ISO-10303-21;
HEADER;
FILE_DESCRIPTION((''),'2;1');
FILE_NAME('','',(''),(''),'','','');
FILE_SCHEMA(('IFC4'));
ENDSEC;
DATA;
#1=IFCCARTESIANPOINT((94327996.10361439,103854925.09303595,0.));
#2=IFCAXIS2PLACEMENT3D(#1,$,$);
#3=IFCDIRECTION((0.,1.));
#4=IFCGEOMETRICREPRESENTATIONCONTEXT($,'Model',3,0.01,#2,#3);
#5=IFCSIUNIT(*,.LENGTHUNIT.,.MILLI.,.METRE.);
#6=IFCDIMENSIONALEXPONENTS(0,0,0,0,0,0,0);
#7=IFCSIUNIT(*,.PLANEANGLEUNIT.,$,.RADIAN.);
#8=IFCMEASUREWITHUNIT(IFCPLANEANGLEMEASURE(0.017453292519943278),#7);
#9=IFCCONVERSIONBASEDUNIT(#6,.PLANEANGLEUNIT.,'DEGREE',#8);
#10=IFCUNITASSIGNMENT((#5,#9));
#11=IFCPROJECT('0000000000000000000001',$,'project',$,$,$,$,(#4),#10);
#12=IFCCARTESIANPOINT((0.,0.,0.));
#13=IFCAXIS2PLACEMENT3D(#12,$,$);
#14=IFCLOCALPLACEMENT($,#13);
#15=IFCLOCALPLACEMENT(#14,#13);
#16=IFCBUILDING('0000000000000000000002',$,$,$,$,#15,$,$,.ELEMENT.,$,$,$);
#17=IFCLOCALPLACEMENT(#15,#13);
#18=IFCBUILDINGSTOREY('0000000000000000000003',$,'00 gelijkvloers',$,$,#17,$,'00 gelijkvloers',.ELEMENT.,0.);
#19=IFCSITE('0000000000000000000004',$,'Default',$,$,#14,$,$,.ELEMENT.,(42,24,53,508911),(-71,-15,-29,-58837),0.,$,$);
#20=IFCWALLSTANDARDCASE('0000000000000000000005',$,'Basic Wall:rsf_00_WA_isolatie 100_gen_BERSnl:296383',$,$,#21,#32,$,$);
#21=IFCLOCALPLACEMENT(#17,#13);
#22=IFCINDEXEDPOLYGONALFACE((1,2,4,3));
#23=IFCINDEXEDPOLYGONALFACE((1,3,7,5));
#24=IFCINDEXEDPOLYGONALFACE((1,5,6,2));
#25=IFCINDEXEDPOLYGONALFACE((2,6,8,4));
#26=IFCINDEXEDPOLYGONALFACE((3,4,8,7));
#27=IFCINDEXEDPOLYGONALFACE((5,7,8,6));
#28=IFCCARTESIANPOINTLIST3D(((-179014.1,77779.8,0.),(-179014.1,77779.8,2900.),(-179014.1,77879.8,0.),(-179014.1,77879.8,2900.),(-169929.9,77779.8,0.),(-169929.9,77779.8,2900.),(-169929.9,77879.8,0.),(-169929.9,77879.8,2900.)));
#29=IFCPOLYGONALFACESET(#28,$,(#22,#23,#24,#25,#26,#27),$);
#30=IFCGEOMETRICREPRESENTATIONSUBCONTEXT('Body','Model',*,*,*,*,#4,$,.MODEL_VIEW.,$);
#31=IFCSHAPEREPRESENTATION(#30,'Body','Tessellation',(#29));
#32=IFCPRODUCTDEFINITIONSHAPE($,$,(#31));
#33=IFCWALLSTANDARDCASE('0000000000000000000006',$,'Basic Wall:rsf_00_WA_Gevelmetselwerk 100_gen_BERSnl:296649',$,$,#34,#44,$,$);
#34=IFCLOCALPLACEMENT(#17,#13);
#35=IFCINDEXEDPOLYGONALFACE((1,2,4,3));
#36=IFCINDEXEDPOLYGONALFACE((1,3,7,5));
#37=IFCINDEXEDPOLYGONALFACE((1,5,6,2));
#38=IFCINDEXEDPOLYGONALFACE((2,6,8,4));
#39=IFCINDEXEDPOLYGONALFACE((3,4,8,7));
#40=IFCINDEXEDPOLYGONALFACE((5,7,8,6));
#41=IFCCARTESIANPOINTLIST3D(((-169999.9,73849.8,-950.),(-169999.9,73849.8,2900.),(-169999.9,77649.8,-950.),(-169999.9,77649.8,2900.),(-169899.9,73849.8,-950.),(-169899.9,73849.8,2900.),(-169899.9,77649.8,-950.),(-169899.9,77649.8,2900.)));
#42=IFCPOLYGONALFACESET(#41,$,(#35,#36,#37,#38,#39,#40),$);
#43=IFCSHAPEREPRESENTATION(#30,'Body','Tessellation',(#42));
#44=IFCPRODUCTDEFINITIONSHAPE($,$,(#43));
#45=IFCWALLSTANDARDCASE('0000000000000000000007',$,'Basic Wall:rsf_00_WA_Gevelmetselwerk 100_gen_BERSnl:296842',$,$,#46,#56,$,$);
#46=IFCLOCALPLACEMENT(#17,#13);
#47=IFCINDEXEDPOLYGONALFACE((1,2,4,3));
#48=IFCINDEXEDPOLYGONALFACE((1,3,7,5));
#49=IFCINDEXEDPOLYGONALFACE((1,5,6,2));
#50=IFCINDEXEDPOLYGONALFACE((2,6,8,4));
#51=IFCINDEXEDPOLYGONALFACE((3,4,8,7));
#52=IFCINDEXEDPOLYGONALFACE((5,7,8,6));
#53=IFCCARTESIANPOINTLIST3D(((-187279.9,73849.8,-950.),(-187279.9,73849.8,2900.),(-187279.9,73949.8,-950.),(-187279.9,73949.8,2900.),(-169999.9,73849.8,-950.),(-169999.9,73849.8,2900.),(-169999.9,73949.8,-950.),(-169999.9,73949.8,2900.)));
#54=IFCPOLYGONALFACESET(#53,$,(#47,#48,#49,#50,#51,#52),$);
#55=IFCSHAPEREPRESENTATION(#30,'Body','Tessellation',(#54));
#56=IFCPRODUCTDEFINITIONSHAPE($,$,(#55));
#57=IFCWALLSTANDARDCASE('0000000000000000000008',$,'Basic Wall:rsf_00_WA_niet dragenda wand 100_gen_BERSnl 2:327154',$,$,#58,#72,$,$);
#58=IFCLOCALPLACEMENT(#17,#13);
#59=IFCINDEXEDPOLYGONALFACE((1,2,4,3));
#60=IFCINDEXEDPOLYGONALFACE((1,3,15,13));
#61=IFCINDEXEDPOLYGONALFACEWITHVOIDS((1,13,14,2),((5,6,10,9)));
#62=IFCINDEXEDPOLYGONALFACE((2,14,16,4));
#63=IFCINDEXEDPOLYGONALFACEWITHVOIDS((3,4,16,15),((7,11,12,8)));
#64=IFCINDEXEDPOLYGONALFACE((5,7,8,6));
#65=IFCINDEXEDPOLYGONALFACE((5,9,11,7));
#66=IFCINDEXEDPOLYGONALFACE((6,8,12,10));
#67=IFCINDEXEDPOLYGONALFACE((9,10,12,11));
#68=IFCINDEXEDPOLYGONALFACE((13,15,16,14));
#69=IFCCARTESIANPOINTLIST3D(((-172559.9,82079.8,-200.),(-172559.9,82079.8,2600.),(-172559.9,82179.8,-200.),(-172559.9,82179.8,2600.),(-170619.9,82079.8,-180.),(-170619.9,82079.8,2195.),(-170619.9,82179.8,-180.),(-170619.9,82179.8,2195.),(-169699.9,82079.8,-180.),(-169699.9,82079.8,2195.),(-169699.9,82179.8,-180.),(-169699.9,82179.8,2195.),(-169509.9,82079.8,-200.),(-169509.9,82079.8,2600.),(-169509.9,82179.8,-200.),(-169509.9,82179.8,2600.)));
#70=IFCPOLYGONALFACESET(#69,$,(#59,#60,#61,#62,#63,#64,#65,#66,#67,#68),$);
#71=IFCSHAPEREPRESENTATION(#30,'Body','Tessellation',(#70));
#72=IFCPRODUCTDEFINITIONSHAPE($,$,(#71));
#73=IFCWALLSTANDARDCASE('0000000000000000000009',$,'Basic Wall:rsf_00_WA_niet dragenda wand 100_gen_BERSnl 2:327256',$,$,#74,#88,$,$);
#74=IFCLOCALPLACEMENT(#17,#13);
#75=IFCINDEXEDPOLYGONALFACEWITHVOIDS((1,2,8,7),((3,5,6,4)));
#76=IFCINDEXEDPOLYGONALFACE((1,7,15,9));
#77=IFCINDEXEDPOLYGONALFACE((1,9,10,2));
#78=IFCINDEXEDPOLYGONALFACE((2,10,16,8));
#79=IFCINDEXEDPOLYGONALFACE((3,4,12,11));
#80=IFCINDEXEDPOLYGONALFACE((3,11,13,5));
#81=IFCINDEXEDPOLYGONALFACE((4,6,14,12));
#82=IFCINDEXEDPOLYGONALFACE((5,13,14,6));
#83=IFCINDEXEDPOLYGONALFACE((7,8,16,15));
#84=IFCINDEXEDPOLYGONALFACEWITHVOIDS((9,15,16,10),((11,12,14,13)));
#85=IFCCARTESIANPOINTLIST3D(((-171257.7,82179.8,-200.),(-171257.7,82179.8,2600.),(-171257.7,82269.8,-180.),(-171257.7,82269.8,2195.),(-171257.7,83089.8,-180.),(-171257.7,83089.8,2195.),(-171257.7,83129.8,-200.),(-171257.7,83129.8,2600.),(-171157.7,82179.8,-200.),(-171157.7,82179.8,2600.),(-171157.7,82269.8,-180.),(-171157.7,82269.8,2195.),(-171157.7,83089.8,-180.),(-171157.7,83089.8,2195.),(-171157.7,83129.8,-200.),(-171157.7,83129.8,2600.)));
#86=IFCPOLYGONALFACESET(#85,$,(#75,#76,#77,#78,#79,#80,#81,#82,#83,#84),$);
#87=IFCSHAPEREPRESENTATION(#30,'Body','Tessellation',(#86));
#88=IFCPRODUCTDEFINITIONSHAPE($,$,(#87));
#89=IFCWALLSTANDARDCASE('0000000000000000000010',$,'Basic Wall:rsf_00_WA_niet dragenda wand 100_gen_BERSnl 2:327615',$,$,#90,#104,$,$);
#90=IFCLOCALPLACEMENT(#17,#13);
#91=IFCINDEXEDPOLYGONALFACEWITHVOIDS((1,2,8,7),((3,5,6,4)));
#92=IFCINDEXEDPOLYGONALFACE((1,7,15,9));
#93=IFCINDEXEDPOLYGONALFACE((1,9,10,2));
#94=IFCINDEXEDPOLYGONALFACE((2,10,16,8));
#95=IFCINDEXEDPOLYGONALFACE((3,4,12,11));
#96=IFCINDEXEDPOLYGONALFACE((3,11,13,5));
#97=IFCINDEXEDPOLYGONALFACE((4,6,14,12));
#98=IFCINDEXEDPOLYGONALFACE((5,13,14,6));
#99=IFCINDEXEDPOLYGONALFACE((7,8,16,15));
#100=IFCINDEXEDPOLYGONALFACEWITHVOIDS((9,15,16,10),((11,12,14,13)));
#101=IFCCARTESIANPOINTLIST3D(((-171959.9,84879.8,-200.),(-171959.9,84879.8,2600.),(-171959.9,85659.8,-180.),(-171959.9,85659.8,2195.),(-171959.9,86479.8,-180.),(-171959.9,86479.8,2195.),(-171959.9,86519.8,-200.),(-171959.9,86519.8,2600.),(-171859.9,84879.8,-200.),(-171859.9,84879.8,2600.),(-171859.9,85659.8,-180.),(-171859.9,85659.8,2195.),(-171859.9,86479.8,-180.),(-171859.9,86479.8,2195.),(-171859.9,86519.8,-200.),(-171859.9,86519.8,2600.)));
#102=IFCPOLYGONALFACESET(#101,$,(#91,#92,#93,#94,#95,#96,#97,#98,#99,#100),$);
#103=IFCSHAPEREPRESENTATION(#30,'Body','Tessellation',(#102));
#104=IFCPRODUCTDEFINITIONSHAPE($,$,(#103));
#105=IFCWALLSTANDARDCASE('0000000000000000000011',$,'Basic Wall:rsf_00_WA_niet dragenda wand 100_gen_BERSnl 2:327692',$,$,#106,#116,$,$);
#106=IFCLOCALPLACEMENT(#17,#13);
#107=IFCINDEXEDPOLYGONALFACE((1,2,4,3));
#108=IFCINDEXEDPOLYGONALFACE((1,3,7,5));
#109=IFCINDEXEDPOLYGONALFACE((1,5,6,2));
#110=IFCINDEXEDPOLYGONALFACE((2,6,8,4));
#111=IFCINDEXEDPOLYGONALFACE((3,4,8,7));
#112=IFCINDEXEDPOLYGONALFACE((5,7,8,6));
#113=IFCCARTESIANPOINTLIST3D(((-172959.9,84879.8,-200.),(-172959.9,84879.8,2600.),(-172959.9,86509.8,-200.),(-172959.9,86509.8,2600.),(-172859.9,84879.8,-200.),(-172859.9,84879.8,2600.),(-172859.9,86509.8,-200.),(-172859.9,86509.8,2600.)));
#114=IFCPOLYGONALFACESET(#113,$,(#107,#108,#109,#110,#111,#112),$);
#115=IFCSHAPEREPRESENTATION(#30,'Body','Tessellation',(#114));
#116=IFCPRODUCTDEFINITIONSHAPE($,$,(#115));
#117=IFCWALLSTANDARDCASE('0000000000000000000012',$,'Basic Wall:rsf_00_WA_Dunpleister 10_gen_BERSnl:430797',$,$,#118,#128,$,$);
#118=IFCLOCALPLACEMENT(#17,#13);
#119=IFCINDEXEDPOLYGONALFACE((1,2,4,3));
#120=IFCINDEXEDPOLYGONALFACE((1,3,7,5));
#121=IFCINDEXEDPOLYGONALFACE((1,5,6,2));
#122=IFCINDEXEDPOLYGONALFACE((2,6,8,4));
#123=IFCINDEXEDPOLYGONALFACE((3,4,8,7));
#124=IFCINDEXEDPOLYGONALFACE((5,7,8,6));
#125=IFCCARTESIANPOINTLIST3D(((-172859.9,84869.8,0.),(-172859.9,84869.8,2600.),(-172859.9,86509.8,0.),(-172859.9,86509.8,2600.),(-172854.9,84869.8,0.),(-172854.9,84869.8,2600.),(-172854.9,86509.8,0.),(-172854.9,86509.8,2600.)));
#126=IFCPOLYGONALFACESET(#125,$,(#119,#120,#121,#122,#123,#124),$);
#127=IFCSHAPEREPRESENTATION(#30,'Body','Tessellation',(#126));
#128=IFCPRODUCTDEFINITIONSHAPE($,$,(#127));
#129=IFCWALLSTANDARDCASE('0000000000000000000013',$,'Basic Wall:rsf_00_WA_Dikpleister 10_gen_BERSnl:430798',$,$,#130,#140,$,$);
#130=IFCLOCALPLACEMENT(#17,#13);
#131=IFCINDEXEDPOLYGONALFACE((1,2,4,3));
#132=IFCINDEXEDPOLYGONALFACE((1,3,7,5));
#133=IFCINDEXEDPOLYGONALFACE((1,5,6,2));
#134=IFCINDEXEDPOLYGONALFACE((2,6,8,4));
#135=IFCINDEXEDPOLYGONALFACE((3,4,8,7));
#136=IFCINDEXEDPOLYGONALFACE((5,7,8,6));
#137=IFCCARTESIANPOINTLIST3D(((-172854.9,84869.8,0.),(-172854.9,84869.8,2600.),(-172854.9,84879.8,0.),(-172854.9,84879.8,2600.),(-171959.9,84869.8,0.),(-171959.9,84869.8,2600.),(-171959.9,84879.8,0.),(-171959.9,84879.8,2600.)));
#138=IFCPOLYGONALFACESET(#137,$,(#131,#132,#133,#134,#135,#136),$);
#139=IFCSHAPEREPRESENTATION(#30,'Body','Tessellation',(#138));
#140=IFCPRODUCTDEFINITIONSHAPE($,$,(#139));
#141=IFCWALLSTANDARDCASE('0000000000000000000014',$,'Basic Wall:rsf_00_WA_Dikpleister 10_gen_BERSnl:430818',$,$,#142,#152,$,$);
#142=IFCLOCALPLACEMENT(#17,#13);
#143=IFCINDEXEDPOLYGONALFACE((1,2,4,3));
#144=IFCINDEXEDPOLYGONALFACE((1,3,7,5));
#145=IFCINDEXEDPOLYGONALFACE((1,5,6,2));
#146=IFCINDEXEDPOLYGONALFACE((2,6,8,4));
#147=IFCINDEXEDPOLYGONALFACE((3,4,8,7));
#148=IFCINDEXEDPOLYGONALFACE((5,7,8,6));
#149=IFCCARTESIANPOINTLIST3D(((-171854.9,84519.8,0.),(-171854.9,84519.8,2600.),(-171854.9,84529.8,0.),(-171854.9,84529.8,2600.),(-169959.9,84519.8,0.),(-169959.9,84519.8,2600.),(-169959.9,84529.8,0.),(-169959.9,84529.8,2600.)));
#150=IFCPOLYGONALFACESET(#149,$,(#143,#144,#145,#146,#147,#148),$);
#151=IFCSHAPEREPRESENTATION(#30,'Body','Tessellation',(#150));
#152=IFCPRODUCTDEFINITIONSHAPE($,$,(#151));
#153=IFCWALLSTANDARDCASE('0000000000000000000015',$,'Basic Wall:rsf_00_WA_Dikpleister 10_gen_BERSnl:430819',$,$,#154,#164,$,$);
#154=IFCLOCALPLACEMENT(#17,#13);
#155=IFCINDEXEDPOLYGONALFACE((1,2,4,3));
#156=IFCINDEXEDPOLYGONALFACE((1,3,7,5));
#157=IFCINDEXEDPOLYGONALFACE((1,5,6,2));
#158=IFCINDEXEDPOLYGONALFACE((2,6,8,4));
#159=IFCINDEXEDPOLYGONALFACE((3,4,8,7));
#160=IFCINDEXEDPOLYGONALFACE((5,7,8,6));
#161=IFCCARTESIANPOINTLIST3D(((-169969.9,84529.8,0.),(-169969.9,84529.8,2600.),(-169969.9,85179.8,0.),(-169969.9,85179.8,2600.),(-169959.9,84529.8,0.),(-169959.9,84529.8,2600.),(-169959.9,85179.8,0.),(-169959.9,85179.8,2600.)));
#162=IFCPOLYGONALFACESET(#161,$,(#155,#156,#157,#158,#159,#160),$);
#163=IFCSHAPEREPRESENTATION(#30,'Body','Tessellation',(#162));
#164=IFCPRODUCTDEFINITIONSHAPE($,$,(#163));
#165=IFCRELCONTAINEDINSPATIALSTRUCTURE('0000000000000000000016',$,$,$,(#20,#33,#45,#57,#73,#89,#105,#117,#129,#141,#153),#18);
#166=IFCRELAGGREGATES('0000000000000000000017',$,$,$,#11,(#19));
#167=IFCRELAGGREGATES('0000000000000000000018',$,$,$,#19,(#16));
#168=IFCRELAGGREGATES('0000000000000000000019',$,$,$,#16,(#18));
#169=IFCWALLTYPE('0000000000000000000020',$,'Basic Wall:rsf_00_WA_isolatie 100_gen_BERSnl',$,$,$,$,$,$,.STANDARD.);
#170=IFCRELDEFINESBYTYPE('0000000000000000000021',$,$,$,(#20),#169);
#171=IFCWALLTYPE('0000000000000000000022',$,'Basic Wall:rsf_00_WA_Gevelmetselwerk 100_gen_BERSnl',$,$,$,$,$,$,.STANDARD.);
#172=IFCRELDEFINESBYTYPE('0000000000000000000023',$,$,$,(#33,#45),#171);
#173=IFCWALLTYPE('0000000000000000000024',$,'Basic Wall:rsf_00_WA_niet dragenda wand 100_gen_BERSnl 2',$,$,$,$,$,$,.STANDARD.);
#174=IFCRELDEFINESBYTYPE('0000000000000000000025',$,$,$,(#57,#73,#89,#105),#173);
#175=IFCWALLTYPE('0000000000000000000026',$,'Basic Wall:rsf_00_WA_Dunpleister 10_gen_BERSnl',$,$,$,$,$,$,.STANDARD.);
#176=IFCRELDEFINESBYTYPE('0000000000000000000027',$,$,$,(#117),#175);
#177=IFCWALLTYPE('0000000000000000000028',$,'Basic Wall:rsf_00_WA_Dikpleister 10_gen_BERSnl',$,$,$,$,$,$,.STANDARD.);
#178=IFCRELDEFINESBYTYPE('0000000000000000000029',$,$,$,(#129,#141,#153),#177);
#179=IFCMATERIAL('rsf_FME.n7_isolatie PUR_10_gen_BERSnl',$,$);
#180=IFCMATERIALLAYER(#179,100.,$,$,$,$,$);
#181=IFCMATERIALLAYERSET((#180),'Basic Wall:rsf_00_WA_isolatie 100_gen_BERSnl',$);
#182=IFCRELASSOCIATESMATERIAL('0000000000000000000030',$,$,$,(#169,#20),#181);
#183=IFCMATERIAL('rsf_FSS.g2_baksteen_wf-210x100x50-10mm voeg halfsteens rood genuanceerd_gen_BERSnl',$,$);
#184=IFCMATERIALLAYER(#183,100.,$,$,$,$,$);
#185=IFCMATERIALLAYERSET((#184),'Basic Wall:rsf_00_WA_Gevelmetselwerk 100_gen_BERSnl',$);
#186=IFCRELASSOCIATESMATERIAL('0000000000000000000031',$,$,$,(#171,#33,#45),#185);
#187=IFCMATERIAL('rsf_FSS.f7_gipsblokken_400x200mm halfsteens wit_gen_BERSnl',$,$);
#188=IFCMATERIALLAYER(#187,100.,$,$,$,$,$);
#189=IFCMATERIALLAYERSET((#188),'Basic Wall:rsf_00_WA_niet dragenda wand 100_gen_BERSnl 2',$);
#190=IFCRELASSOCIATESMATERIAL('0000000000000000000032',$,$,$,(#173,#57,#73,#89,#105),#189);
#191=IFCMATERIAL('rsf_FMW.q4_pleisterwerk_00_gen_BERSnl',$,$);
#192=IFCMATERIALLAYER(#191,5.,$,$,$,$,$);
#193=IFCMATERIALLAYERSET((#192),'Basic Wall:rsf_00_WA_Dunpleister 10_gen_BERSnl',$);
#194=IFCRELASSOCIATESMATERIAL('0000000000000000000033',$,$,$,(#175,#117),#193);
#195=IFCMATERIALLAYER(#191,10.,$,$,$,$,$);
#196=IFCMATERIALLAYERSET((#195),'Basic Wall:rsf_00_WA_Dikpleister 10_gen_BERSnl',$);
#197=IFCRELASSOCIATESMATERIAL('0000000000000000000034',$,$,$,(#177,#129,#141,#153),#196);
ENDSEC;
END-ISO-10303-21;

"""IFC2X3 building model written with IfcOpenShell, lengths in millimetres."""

from ifc_helpers import new_model, entity, si_unit, converted_unit, direction, frame, frame_2d, origin, place, context, subcontext, project, spatial, rectangle, extrude, material, layer, layer_set, layer_usage, type_object, element, save


model = new_model("IFC2X3")

# Units and contexts
model_context = context("Model", 3, precision=0.01, world=frame((94327996.10361439, 103854925.09303595, 0.0)), true_north=direction((0.0, 1.0)))
body_context = subcontext(model_context, "Body", "Model", "MODEL_VIEW")
ifc_project = project(units=[si_unit("LENGTHUNIT", "METRE", prefix="MILLI"), converted_unit("PLANEANGLEUNIT", "DEGREE", entity("IfcPlaneAngleMeasure", 0.017453292519943278), si_unit("PLANEANGLEUNIT", "RADIAN"), dimensions=[0, 0, 0, 0, 0, 0, 0])], contexts=[model_context])

# Site, building, storey
site_placement = place(None, origin())
site = spatial("IfcSite", under=ifc_project, at=site_placement, Name="Default", CompositionType="ELEMENT", RefLatitude=(42, 24, 53, 508911), RefLongitude=(-71, -15, -29, -58837), RefElevation=0.0)
building_placement = place(site_placement, origin())
building = spatial("IfcBuilding", under=site, at=building_placement, CompositionType="ELEMENT")
storey_placement = place(building_placement, origin())
storey = spatial("IfcBuildingStorey", under=building, at=storey_placement, Name="00 gelijkvloers", LongName="00 gelijkvloers", CompositionType="ELEMENT", Elevation=0.0)

# Walls
ifc_material_1 = material(Name="rsf_FME.n7_isolatie PUR_10_gen_BERSnl")
ifc_layer_1 = layer(ifc_material_1, 100.0)
ifc_layer_set_1 = layer_set([ifc_layer_1], Name="Basic Wall:rsf_00_WA_isolatie 100_gen_BERSnl")
ifc_layer_usage_1 = layer_usage(ifc_layer_set_1, "AXIS2", "NEGATIVE", 50.0)
wall_type_1 = type_object("IfcWallType", Name="Basic Wall:rsf_00_WA_isolatie 100_gen_BERSnl", PredefinedType="STANDARD", material=ifc_layer_set_1)
wall_1_placement = place(storey_placement, frame((-169929.9, 77829.8, 0.0), z_axis=(0.0, 0.0, 1.0), x_axis=(-1.0, 0.0, 0.0)))
element("IfcWallStandardCase", 1, at=wall_1_placement, inside=storey, type_object=wall_type_1, material=ifc_layer_usage_1, Name="Basic Wall:rsf_00_WA_isolatie 100_gen_BERSnl:296383", context=body_context, shape_type="SweptSolid", body=[
    extrude(rectangle(XDim=9084.2, YDim=100.0, at=frame_2d((4542.1, 0.0), x_axis=(-1.0, 0.0))), origin(), (0.0, 0.0, 1.0), 2900.0),
])
ifc_material_2 = material(Name="rsf_FSS.g2_baksteen_wf-210x100x50-10mm voeg halfsteens rood genuanceerd_gen_BERSnl")
ifc_layer_2 = layer(ifc_material_2, 100.0)
ifc_layer_set_2 = layer_set([ifc_layer_2], Name="Basic Wall:rsf_00_WA_Gevelmetselwerk 100_gen_BERSnl")
ifc_layer_usage_2 = layer_usage(ifc_layer_set_2, "AXIS2", "POSITIVE", -50.0)
wall_type_2 = type_object("IfcWallType", Name="Basic Wall:rsf_00_WA_Gevelmetselwerk 100_gen_BERSnl", PredefinedType="STANDARD", material=ifc_layer_set_2)
wall_2_placement = place(storey_placement, frame((-169949.9, 77649.8, -950.0), z_axis=(0.0, 0.0, 1.0), x_axis=(0.0, -1.0, 0.0)))
element("IfcWallStandardCase", 2, at=wall_2_placement, inside=storey, type_object=wall_type_2, material=ifc_layer_usage_2, Name="Basic Wall:rsf_00_WA_Gevelmetselwerk 100_gen_BERSnl:296649", context=body_context, shape_type="SweptSolid", body=[
    extrude(rectangle(XDim=3800.0, YDim=100.0, at=frame_2d((1900.0, 0.0), x_axis=(-1.0, 0.0))), origin(), (0.0, 0.0, 1.0), 3850.0),
])
ifc_layer_usage_3 = layer_usage(ifc_layer_set_2, "AXIS2", "POSITIVE", -50.0)
wall_3_placement = place(storey_placement, frame((-169999.9, 73899.8, -950.0), z_axis=(0.0, 0.0, 1.0), x_axis=(-1.0, 0.0, 0.0)))
element("IfcWallStandardCase", 3, at=wall_3_placement, inside=storey, type_object=wall_type_2, material=ifc_layer_usage_3, Name="Basic Wall:rsf_00_WA_Gevelmetselwerk 100_gen_BERSnl:296842", context=body_context, shape_type="SweptSolid", body=[
    extrude(rectangle(XDim=17280.0, YDim=100.0, at=frame_2d((8640.0, 0.0), x_axis=(-1.0, 0.0))), origin(), (0.0, 0.0, 1.0), 3850.0),
])

# Walls, openings
ifc_material_3 = material(Name="rsf_FSS.f7_gipsblokken_400x200mm halfsteens wit_gen_BERSnl")
ifc_layer_3 = layer(ifc_material_3, 100.0)
ifc_layer_set_3 = layer_set([ifc_layer_3], Name="Basic Wall:rsf_00_WA_niet dragenda wand 100_gen_BERSnl 2")
ifc_layer_usage_4 = layer_usage(ifc_layer_set_3, "AXIS2", "NEGATIVE", 50.0)
wall_type_3 = type_object("IfcWallType", Name="Basic Wall:rsf_00_WA_niet dragenda wand 100_gen_BERSnl 2", PredefinedType="STANDARD", material=ifc_layer_set_3)
wall_4_placement = place(storey_placement, frame((-172559.9, 82129.8, -200.0)))
wall_4 = element("IfcWallStandardCase", 4, at=wall_4_placement, inside=storey, type_object=wall_type_3, material=ifc_layer_usage_4, Name="Basic Wall:rsf_00_WA_niet dragenda wand 100_gen_BERSnl 2:327154", context=body_context, shape_type="SweptSolid", body=[
    extrude(rectangle(XDim=3050.0, YDim=100.0, at=frame_2d((1525.0, 0.0), x_axis=(-1.0, 0.0))), origin(), (0.0, 0.0, 1.0), 2800.0),
])
opening_1_placement = place(wall_4_placement, frame((2860.0, 50.0, 20.0)))
element("IfcOpeningElement", 5, at=opening_1_placement, cuts=wall_4, ObjectType="Opening", context=body_context, shape_type="SweptSolid", body=[
    extrude(rectangle(XDim=2375.0, YDim=920.0, at=frame_2d((1187.5, 460.0), x_axis=(-1.0, 0.0))), frame((0.0, 0.0, 0.0), z_axis=(0.0, -1.0, 0.0), x_axis=(0.0, 0.0, 1.0)), (0.0, 0.0, 1.0), 100.0),
])
ifc_layer_usage_5 = layer_usage(ifc_layer_set_3, "AXIS2", "NEGATIVE", 50.0)
wall_5_placement = place(storey_placement, frame((-171207.7, 82179.8, -200.0), z_axis=(0.0, 0.0, 1.0), x_axis=(0.0, 1.0, 0.0)))
wall_5 = element("IfcWallStandardCase", 6, at=wall_5_placement, inside=storey, type_object=wall_type_3, material=ifc_layer_usage_5, Name="Basic Wall:rsf_00_WA_niet dragenda wand 100_gen_BERSnl 2:327256", context=body_context, shape_type="SweptSolid", body=[
    extrude(rectangle(XDim=950.0, YDim=100.0, at=frame_2d((475.0, 0.0), x_axis=(-1.0, 0.0))), origin(), (0.0, 0.0, 1.0), 2800.0),
])
opening_2_placement = place(wall_5_placement, frame((910.0, 50.0, 20.0)))
element("IfcOpeningElement", 7, at=opening_2_placement, cuts=wall_5, ObjectType="Opening", context=body_context, shape_type="SweptSolid", body=[
    extrude(rectangle(XDim=2375.0, YDim=820.0, at=frame_2d((1187.5, 410.0), x_axis=(-1.0, 0.0))), frame((0.0, 0.0, 0.0), z_axis=(0.0, -1.0, 0.0), x_axis=(0.0, 0.0, 1.0)), (0.0, 0.0, 1.0), 100.0),
])
ifc_layer_usage_6 = layer_usage(ifc_layer_set_3, "AXIS2", "NEGATIVE", 50.0)
wall_6_placement = place(storey_placement, frame((-171909.9, 84879.8, -200.0), z_axis=(0.0, 0.0, 1.0), x_axis=(0.0, 1.0, 0.0)))
wall_6 = element("IfcWallStandardCase", 8, at=wall_6_placement, inside=storey, type_object=wall_type_3, material=ifc_layer_usage_6, Name="Basic Wall:rsf_00_WA_niet dragenda wand 100_gen_BERSnl 2:327615", context=body_context, shape_type="SweptSolid", body=[
    extrude(rectangle(XDim=1640.0, YDim=100.0, at=frame_2d((820.0, 0.0), x_axis=(-1.0, 0.0))), origin(), (0.0, 0.0, 1.0), 2800.0),
])
opening_3_placement = place(wall_6_placement, frame((1600.0, 50.0, 20.0)))
element("IfcOpeningElement", 9, at=opening_3_placement, cuts=wall_6, ObjectType="Opening", context=body_context, shape_type="SweptSolid", body=[
    extrude(rectangle(XDim=2375.0, YDim=820.0, at=frame_2d((1187.5, 410.0), x_axis=(-1.0, 0.0))), frame((0.0, 0.0, 0.0), z_axis=(0.0, -1.0, 0.0), x_axis=(0.0, 0.0, 1.0)), (0.0, 0.0, 1.0), 100.0),
])

# Walls
ifc_layer_usage_7 = layer_usage(ifc_layer_set_3, "AXIS2", "NEGATIVE", 50.0)
wall_7_placement = place(storey_placement, frame((-172909.9, 84879.8, -200.0), z_axis=(0.0, 0.0, 1.0), x_axis=(0.0, 1.0, 0.0)))
element("IfcWallStandardCase", 10, at=wall_7_placement, inside=storey, type_object=wall_type_3, material=ifc_layer_usage_7, Name="Basic Wall:rsf_00_WA_niet dragenda wand 100_gen_BERSnl 2:327692", context=body_context, shape_type="SweptSolid", body=[
    extrude(rectangle(XDim=1630.0, YDim=100.0, at=frame_2d((815.0, 0.0), x_axis=(-1.0, 0.0))), origin(), (0.0, 0.0, 1.0), 2800.0),
])
ifc_material_4 = material(Name="rsf_FMW.q4_pleisterwerk_00_gen_BERSnl")
ifc_layer_4 = layer(ifc_material_4, 5.0)
ifc_layer_set_4 = layer_set([ifc_layer_4], Name="Basic Wall:rsf_00_WA_Dunpleister 10_gen_BERSnl")
ifc_layer_usage_8 = layer_usage(ifc_layer_set_4, "AXIS2", "POSITIVE", -2.5)
wall_type_4 = type_object("IfcWallType", Name="Basic Wall:rsf_00_WA_Dunpleister 10_gen_BERSnl", PredefinedType="STANDARD", material=ifc_layer_set_4)
wall_8_placement = place(storey_placement, frame((-172857.4, 84869.8, 0.0), z_axis=(0.0, 0.0, 1.0), x_axis=(0.0, 1.0, 0.0)))
element("IfcWallStandardCase", 11, at=wall_8_placement, inside=storey, type_object=wall_type_4, material=ifc_layer_usage_8, Name="Basic Wall:rsf_00_WA_Dunpleister 10_gen_BERSnl:430797", context=body_context, shape_type="SweptSolid", body=[
    extrude(rectangle(XDim=1640.0, YDim=5.0, at=frame_2d((820.0, 0.0), x_axis=(-1.0, 0.0))), origin(), (0.0, 0.0, 1.0), 2600.0),
])

# Walls
ifc_layer_5 = layer(ifc_material_4, 10.0)
ifc_layer_set_5 = layer_set([ifc_layer_5], Name="Basic Wall:rsf_00_WA_Dikpleister 10_gen_BERSnl")
ifc_layer_usage_9 = layer_usage(ifc_layer_set_5, "AXIS2", "POSITIVE", -5.0)
wall_type_5 = type_object("IfcWallType", Name="Basic Wall:rsf_00_WA_Dikpleister 10_gen_BERSnl", PredefinedType="STANDARD", material=ifc_layer_set_5)
wall_9_placement = place(storey_placement, frame((-171959.9, 84874.8, 0.0), z_axis=(0.0, 0.0, 1.0), x_axis=(-1.0, 0.0, 0.0)))
element("IfcWallStandardCase", 12, at=wall_9_placement, inside=storey, type_object=wall_type_5, material=ifc_layer_usage_9, Name="Basic Wall:rsf_00_WA_Dikpleister 10_gen_BERSnl:430798", context=body_context, shape_type="SweptSolid", body=[
    extrude(rectangle(XDim=895.0, YDim=10.0, at=frame_2d((447.5, 0.0), x_axis=(-1.0, 0.0))), origin(), (0.0, 0.0, 1.0), 2600.0),
])
ifc_layer_usage_10 = layer_usage(ifc_layer_set_5, "AXIS2", "POSITIVE", -5.0)
wall_10_placement = place(storey_placement, frame((-169959.9, 84524.8, 0.0), z_axis=(0.0, 0.0, 1.0), x_axis=(-1.0, 0.0, 0.0)))
element("IfcWallStandardCase", 13, at=wall_10_placement, inside=storey, type_object=wall_type_5, material=ifc_layer_usage_10, Name="Basic Wall:rsf_00_WA_Dikpleister 10_gen_BERSnl:430818", context=body_context, shape_type="SweptSolid", body=[
    extrude(rectangle(XDim=1895.0, YDim=10.0, at=frame_2d((947.5, 0.0), x_axis=(-1.0, 0.0))), origin(), (0.0, 0.0, 1.0), 2600.0),
])
ifc_layer_usage_11 = layer_usage(ifc_layer_set_5, "AXIS2", "POSITIVE", -5.0)
wall_11_placement = place(storey_placement, frame((-169964.9, 85179.8, 0.0), z_axis=(0.0, 0.0, 1.0), x_axis=(0.0, -1.0, 0.0)))
element("IfcWallStandardCase", 14, at=wall_11_placement, inside=storey, type_object=wall_type_5, material=ifc_layer_usage_11, Name="Basic Wall:rsf_00_WA_Dikpleister 10_gen_BERSnl:430819", context=body_context, shape_type="SweptSolid", body=[
    extrude(rectangle(XDim=650.0, YDim=10.0, at=frame_2d((325.0, 0.0), x_axis=(-1.0, 0.0))), origin(), (0.0, 0.0, 1.0), 2600.0),
])

save(model, "model.ifc")
